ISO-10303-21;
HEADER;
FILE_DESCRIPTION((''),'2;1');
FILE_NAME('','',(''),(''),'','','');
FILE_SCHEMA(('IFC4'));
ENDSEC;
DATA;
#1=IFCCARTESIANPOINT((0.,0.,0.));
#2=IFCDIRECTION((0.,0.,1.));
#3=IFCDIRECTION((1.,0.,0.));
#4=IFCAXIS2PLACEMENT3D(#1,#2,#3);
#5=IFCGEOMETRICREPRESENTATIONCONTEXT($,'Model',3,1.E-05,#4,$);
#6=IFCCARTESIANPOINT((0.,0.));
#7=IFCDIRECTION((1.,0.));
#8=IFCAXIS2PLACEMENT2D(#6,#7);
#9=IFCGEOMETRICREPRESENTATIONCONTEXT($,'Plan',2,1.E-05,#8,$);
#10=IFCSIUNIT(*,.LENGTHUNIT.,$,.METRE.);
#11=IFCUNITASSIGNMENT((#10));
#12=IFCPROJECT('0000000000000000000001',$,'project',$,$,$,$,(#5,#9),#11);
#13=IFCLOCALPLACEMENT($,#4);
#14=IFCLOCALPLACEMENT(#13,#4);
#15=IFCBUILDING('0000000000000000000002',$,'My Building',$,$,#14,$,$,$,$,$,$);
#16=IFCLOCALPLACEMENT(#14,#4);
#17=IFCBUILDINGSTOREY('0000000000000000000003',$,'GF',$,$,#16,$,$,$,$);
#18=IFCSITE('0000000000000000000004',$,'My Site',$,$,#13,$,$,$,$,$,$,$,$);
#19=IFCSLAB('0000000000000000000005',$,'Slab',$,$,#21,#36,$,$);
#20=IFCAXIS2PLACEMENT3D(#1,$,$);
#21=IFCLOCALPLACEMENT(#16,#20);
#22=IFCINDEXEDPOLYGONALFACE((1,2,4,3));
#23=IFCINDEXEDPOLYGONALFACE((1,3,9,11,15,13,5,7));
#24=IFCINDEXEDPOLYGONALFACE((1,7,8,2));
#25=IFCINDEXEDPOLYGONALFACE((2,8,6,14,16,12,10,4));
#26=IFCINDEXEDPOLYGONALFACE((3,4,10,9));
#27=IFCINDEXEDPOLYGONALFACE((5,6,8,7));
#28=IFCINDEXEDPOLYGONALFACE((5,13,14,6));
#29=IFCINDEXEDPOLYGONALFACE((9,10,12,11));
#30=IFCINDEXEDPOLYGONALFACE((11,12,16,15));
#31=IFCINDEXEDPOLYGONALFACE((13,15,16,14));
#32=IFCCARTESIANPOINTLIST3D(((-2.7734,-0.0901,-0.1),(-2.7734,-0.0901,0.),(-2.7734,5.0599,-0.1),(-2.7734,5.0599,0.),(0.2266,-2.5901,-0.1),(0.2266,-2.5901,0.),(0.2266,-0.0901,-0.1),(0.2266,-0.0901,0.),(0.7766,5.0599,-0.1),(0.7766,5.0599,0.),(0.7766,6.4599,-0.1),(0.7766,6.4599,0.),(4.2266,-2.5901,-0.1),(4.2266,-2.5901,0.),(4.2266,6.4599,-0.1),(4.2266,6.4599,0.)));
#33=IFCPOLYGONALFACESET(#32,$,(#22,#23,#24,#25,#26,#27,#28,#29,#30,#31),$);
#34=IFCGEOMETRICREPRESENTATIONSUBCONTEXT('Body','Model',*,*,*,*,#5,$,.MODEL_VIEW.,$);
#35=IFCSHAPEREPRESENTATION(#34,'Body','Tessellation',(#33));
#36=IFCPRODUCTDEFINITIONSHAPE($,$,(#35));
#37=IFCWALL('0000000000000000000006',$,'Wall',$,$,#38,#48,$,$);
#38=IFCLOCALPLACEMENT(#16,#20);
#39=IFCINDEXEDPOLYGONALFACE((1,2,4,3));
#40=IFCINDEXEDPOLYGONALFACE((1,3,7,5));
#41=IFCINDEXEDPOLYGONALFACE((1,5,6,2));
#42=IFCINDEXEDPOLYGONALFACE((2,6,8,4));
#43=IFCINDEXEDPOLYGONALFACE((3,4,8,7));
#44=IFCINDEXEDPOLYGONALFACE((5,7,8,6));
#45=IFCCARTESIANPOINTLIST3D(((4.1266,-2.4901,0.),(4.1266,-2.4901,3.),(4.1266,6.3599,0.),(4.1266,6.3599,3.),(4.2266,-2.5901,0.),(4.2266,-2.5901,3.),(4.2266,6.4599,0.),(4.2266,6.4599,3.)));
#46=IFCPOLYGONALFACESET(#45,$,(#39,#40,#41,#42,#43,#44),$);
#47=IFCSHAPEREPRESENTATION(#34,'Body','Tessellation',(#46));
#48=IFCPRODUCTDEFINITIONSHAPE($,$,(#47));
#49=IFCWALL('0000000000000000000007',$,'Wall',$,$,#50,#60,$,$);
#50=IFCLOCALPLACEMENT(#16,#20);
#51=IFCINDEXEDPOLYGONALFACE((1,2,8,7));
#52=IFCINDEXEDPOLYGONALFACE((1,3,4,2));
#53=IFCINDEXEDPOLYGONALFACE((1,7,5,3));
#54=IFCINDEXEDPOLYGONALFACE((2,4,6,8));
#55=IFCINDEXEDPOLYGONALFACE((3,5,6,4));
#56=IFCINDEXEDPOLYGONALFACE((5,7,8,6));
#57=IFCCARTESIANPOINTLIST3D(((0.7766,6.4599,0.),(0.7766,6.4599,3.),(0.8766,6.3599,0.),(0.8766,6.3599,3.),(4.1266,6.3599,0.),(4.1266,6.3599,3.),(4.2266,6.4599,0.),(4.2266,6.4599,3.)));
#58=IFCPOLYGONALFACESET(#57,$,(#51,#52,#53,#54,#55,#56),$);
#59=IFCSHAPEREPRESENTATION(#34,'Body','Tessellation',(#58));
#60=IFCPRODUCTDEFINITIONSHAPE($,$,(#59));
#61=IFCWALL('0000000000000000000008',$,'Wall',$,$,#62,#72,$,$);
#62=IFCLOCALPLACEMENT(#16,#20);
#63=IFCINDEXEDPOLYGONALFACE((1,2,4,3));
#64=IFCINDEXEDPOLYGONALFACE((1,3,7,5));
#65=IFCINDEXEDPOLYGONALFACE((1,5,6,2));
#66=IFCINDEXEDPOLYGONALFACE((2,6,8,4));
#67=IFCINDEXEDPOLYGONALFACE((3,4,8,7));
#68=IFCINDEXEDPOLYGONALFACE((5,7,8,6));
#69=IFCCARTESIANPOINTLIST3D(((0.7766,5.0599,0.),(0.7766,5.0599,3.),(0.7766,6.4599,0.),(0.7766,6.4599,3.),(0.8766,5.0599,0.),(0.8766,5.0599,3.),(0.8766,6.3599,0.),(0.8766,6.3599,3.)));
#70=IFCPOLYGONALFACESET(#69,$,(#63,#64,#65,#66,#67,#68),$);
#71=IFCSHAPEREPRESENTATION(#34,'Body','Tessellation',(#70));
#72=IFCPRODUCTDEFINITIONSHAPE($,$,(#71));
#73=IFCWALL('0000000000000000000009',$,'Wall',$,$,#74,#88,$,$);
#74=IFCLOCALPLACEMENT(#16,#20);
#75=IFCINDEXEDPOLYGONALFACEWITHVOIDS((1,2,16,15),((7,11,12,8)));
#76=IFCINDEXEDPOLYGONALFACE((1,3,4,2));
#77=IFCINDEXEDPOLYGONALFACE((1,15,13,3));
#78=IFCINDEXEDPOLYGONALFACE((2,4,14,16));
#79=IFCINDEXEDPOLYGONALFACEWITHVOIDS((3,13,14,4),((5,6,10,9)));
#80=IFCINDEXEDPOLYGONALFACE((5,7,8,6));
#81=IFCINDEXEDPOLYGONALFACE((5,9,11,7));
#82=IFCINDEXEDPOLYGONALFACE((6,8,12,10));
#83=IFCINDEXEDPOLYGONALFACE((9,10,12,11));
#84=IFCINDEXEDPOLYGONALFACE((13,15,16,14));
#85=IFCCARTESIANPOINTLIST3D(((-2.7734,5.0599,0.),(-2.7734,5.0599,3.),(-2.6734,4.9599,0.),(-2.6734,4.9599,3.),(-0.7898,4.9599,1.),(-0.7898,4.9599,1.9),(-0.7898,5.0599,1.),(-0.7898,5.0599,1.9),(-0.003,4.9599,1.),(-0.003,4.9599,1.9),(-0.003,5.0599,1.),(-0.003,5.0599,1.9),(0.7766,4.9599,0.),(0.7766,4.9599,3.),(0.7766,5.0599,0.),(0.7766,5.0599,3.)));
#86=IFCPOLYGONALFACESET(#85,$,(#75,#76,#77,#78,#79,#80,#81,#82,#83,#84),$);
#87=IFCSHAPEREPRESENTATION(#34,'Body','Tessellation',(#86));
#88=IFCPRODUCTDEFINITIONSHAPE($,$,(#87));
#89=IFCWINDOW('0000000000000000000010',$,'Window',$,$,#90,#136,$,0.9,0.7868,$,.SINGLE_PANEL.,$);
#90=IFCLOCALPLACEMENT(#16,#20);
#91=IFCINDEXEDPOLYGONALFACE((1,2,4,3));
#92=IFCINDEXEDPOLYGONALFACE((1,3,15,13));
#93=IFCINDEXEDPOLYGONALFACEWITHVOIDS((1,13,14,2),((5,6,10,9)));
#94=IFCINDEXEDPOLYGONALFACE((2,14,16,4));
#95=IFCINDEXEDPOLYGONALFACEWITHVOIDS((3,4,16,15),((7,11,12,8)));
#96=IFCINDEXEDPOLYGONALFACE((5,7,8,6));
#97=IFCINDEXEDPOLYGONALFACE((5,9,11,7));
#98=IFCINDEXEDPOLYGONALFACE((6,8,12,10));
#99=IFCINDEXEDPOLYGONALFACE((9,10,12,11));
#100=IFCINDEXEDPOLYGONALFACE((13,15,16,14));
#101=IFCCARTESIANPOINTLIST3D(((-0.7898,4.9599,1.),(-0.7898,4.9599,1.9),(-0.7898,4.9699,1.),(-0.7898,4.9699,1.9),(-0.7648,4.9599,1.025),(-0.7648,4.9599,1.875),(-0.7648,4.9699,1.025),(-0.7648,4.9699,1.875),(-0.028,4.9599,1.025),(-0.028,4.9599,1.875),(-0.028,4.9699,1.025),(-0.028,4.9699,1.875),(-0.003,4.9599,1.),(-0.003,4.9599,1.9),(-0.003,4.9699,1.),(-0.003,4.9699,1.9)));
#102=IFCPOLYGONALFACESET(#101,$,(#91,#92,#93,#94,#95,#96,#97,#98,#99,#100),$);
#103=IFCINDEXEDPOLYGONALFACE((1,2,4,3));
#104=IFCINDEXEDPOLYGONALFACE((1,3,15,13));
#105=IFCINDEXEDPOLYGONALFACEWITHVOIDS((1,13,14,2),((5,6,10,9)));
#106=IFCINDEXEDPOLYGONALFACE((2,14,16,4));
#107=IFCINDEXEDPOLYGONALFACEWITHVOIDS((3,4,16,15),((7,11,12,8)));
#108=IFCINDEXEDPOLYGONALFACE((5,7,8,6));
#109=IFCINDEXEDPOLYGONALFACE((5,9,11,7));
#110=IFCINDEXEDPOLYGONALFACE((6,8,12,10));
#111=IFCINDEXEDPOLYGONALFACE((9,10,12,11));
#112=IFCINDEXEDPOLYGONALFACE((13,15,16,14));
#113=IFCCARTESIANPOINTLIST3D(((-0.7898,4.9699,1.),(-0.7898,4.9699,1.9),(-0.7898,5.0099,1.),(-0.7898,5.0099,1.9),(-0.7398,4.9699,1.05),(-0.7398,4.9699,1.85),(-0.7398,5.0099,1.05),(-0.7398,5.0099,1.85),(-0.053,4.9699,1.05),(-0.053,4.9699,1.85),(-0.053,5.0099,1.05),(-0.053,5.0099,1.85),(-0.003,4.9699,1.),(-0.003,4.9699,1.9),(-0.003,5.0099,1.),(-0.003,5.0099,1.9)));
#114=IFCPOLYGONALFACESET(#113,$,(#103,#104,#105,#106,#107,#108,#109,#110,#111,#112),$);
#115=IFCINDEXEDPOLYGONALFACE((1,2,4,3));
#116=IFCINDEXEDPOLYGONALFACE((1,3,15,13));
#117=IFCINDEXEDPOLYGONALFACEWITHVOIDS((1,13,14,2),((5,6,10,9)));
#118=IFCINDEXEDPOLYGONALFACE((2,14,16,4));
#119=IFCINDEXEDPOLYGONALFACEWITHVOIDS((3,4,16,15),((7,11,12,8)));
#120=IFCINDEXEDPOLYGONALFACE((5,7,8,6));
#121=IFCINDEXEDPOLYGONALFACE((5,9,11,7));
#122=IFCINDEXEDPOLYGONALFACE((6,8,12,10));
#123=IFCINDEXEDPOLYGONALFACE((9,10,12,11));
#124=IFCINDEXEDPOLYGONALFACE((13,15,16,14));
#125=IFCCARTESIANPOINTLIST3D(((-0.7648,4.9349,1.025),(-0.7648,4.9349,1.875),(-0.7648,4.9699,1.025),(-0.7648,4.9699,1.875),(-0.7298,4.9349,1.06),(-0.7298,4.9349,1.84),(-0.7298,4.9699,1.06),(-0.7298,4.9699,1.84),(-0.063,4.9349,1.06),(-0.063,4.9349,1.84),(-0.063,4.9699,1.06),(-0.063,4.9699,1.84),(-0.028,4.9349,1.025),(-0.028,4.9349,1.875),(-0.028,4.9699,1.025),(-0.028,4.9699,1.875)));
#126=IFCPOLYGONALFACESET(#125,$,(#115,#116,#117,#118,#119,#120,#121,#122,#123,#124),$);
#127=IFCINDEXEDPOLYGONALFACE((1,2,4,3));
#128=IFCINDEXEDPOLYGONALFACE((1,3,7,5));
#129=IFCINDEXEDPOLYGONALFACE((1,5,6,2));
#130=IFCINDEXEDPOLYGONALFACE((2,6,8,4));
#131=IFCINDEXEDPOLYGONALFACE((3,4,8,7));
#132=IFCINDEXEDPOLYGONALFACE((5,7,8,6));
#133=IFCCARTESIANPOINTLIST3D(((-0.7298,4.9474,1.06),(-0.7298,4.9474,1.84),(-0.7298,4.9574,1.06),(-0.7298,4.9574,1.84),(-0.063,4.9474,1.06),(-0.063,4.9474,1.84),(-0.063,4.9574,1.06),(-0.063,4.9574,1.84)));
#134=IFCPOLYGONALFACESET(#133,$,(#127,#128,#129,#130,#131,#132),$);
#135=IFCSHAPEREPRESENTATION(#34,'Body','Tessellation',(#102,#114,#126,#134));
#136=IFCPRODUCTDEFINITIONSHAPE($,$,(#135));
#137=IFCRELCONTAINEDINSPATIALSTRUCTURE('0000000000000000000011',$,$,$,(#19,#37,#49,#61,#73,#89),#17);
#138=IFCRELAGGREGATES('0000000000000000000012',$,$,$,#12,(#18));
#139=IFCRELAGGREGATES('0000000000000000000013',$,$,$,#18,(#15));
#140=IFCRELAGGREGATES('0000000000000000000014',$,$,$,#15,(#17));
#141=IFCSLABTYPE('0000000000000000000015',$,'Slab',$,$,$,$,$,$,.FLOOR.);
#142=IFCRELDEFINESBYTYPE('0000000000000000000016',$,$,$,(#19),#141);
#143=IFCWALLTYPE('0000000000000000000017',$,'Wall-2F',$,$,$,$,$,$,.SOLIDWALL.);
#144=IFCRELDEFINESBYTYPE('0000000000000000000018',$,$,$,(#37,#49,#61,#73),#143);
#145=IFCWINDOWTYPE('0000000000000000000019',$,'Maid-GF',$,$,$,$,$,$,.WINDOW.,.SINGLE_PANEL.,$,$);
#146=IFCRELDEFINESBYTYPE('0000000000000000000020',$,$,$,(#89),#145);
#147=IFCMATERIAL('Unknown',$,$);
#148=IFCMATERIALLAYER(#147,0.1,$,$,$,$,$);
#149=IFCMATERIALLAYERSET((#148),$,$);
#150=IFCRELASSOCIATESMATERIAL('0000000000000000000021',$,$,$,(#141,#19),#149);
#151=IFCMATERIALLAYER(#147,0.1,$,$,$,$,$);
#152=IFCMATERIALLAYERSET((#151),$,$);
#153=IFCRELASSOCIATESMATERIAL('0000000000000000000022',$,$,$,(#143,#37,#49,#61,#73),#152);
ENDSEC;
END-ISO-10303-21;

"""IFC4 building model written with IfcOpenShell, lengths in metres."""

from ifc_helpers import new_model, entity, si_unit, frame, origin_with_axes, origin_2d_with_axis, place, context, subcontext, project, spatial, line, indexed_curve, outline, extrude, shape, source, transform, mapped, material, layer, layer_set, layer_usage, type_object, type_shapes, element, fill, save


model = new_model("IFC4")

# Units and contexts
model_context = context("Model", 3, precision=1e-05, world=origin_with_axes())
plan_context = context("Plan", 2, precision=1e-05, world=origin_2d_with_axis())
body_context_1 = subcontext(model_context, "Body", "Model", "MODEL_VIEW")
body_context_2 = subcontext(plan_context, "Body", "Plan", "PLAN_VIEW")
ifc_project = project(units=[si_unit("LENGTHUNIT", "METRE")], contexts=[model_context, plan_context])

# Site, building, storey
site_placement = place(None, origin_with_axes())
site = spatial("IfcSite", under=ifc_project, at=site_placement, Name="My Site")
building_placement = place(site_placement, origin_with_axes())
building = spatial("IfcBuilding", under=site, at=building_placement, Name="My Building")
storey_placement = place(building_placement, origin_with_axes())
storey = spatial("IfcBuildingStorey", under=building, at=storey_placement, Name="GF")

# Slab
ifc_material = material(Name="Unknown")
ifc_layer_1 = layer(ifc_material, 0.1)
ifc_layer_set_1 = layer_set([ifc_layer_1])
ifc_layer_usage_1 = layer_usage(ifc_layer_set_1, "AXIS3", "POSITIVE", -0.1)
slab_type = type_object("IfcSlabType", Name="Slab", PredefinedType="FLOOR", material=ifc_layer_set_1)
slab_placement = place(storey_placement, frame((4.2266, -2.5901, 0.0), z_axis=(0.0, 0.0, 1.0), x_axis=(1.0, 0.0, 0.0)))
element("IfcSlab", 1, at=slab_placement, inside=storey, type_object=slab_type, material=ifc_layer_usage_1, Name="Slab", context=body_context_1, shape_type="SweptSolid", body=[
    extrude(outline(indexed_curve([(0.0, 0.0), (0.0, 9.05), (-3.45, 9.05), (-3.45, 7.65), (-7.0, 7.65), (-7.0, 2.5), (-4.0, 2.5), (-4.0, 0.0), (0.0, 0.0)])), frame((0.0, 0.0, -0.1), z_axis=(0.0, 0.0, 1.0), x_axis=(1.0, 0.0, 0.0)), (0.0, 0.0, 1.0), 0.1),
])

# Shared definitions
ifc_layer_2 = layer(ifc_material, 0.1)
ifc_layer_set_2 = layer_set([ifc_layer_2])
wall_type = type_object("IfcWallType", Name="Wall-2F", PredefinedType="SOLIDWALL", material=ifc_layer_set_2)

# Walls
ifc_layer_usage_2 = layer_usage(ifc_layer_set_2, "AXIS2", "POSITIVE", 0.0)
wall_1_placement = place(storey_placement, frame((4.2266, -2.5901, 0.0), z_axis=(0.0, 0.0, 1.0), x_axis=(0.0, 1.0, 0.0)))
element("IfcWall", 2, at=wall_1_placement, inside=storey, type_object=wall_type, material=ifc_layer_usage_2, Name="Wall", context=body_context_1, shape_type="SweptSolid", body=[
    extrude(outline(indexed_curve([(0.0, 0.0), (0.1, 0.1), (8.95, 0.1), (9.05, 0.0)], segments=[line(1, 2, 3, 4, 1)])), origin_with_axes(), (0.0, 0.0, 1.0), 3.0),
])
ifc_layer_usage_3 = layer_usage(ifc_layer_set_2, "AXIS2", "POSITIVE", 0.0)
wall_2_placement = place(storey_placement, frame((4.2266, 6.4599, 0.0), z_axis=(0.0, 0.0, 1.0), x_axis=(-1.0, 0.0, 0.0)))
element("IfcWall", 3, at=wall_2_placement, inside=storey, type_object=wall_type, material=ifc_layer_usage_3, Name="Wall", context=body_context_1, shape_type="SweptSolid", body=[
    extrude(outline(indexed_curve([(0.0, 0.0), (0.1, 0.1), (3.35, 0.1), (3.45, 0.0)], segments=[line(1, 2, 3, 4, 1)])), origin_with_axes(), (0.0, 0.0, 1.0), 3.0),
])
ifc_layer_usage_4 = layer_usage(ifc_layer_set_2, "AXIS2", "POSITIVE", 0.0)
wall_3_placement = place(storey_placement, frame((0.7766, 6.4599, 0.0), z_axis=(0.0, 0.0, 1.0), x_axis=(0.0, -1.0, 0.0)))
element("IfcWall", 4, at=wall_3_placement, inside=storey, type_object=wall_type, material=ifc_layer_usage_4, Name="Wall", context=body_context_1, shape_type="SweptSolid", body=[
    extrude(outline(indexed_curve([(0.0, 0.0), (0.1, 0.1), (1.4, 0.1), (1.4, 0.0)], segments=[line(1, 2, 3, 4, 1)])), origin_with_axes(), (0.0, 0.0, 1.0), 3.0),
])

# Wall, opening, window
ifc_layer_usage_5 = layer_usage(ifc_layer_set_2, "AXIS2", "POSITIVE", 0.0)
wall_4_placement = place(storey_placement, frame((0.7766, 5.0599, 0.0), z_axis=(0.0, 0.0, 1.0), x_axis=(-1.0, 0.0, 0.0)))
wall_4 = element("IfcWall", 5, at=wall_4_placement, inside=storey, type_object=wall_type, material=ifc_layer_usage_5, Name="Wall", context=body_context_1, shape_type="SweptSolid", body=[
    extrude(outline(indexed_curve([(0.0, 0.0), (0.0, 0.1), (3.45, 0.1), (3.55, 0.0)], segments=[line(1, 2, 3, 4, 1)])), origin_with_axes(), (0.0, 0.0, 1.0), 3.0),
])
shared_shape_1 = source(origin_with_axes(), body_context_1, "Body", "SweptSolid", [
    extrude(outline(indexed_curve([(0.0, 0.0), (0.7868, 0.0), (0.7868, 0.9), (0.0, 0.9)], segments=[line(1, 2, 3, 4, 1)])), frame((0.0, -0.6, 0.0), z_axis=(0.0, -1.0, 0.0), x_axis=(1.0, 0.0, 0.0)), (0.0, 0.0, -1.0), 1.2),
])
opening_1_placement = place(wall_4_placement, frame((0.7796, 0.0, 1.0), z_axis=(0.0, 0.0, 1.0), x_axis=(1.0, 0.0, 0.0)))
opening_1 = element("IfcOpeningElement", 6, at=opening_1_placement, cuts=wall_4, PredefinedType="OPENING", context=body_context_1, shape_type="MappedRepresentation", body=[
    mapped(shared_shape_1, transform((0.0, 0.0, 0.0), x_axis=(1.0, 0.0, 0.0), y_axis=(0.0, 1.0, 0.0), z_axis=(0.0, 0.0, 1.0), scale=1.0)),
])
window_type_1 = type_object("IfcWindowType", Name="Maid-GF", PartitioningType="SINGLE_PANEL", PredefinedType="WINDOW")
shared_shape_2 = source(origin_with_axes(), body_context_1, "Body", "SweptSolid", [
    extrude(outline(indexed_curve([(0.0, 0.0), (0.7868, 0.0), (0.7868, 0.9), (0.0, 0.9)], segments=[line(1, 2, 3, 4, 1)]), holes=[indexed_curve([(0.025, 0.025), (0.7618, 0.025), (0.7618, 0.875), (0.025, 0.875)], segments=[line(1, 2, 3, 4, 1)])]), frame((0.0, 0.09, 0.0), z_axis=(0.0, -1.0, 0.0), x_axis=(1.0, 0.0, 0.0)), (0.0, 0.0, -1.0), 0.01),
    extrude(outline(indexed_curve([(0.0, 0.0), (0.7868, 0.0), (0.7868, 0.9), (0.0, 0.9)], segments=[line(1, 2, 3, 4, 1)]), holes=[indexed_curve([(0.05, 0.05), (0.7368, 0.05), (0.7368, 0.85), (0.05, 0.85)], segments=[line(1, 2, 3, 4, 1)])]), frame((0.0, 0.05, 0.0), z_axis=(0.0, -1.0, 0.0), x_axis=(1.0, 0.0, 0.0)), (0.0, 0.0, -1.0), 0.04),
    extrude(outline(indexed_curve([(0.0, 0.0), (0.7368, 0.0), (0.7368, 0.85), (0.0, 0.85)], segments=[line(1, 2, 3, 4, 1)]), holes=[indexed_curve([(0.035, 0.035), (0.7018, 0.035), (0.7018, 0.815), (0.035, 0.815)], segments=[line(1, 2, 3, 4, 1)])]), frame((0.025, 0.09, 0.025), z_axis=(0.0, -1.0, 0.0), x_axis=(1.0, 0.0, 0.0)), (0.0, 0.0, -1.0), 0.035),
    extrude(outline(indexed_curve([(0.035, 0.035), (0.7018, 0.035), (0.7018, 0.815), (0.035, 0.815)], segments=[line(1, 2, 3, 4, 1)])), frame((0.025, 0.1025, 0.025), z_axis=(0.0, -1.0, 0.0), x_axis=(1.0, 0.0, 0.0)), (0.0, 0.0, -1.0), 0.01),
])
shared_shape_3 = source(origin_with_axes(), body_context_2, "Body", "Curve2D", [
    entity("IfcIndexedPolyCurve", entity("IfcCartesianPointList2D", [[0.05, 0.05], [0.7368, 0.05]])),
    entity("IfcIndexedPolyCurve", entity("IfcCartesianPointList2D", [[0.0, 0.1], [0.025, 0.1], [0.025, 0.09], [0.05, 0.09], [0.05, 0.05], [0.0, 0.05]]), [entity("IfcLineIndex", [1, 2, 3, 4, 5, 6, 1])]),
    entity("IfcIndexedPolyCurve", entity("IfcCartesianPointList2D", [[0.7868, 0.1], [0.7618, 0.1], [0.7618, 0.09], [0.7368, 0.09], [0.7368, 0.05], [0.7868, 0.05]]), [entity("IfcLineIndex", [1, 2, 3, 4, 5, 6, 1])]),
    entity("IfcIndexedPolyCurve", entity("IfcCartesianPointList2D", [[0.025, 0.09], [0.06, 0.09], [0.06, 0.125], [0.025, 0.125]]), [entity("IfcLineIndex", [1, 2, 3, 4, 1])]),
    entity("IfcIndexedPolyCurve", entity("IfcCartesianPointList2D", [[0.7618, 0.09], [0.7268, 0.09], [0.7268, 0.125], [0.7618, 0.125]]), [entity("IfcLineIndex", [1, 2, 3, 4, 1])]),
    entity("IfcIndexedPolyCurve", entity("IfcCartesianPointList2D", [[0.06, 0.09], [0.7268, 0.09]])),
    entity("IfcIndexedPolyCurve", entity("IfcCartesianPointList2D", [[0.06, 0.125], [0.7268, 0.125]])),
    entity("IfcIndexedPolyCurve", entity("IfcCartesianPointList2D", [[0.06, 0.1075], [0.7268, 0.1075]])),
])
type_shapes(window_type_1, [shared_shape_2, shared_shape_3])
window_1_placement = place(opening_1_placement, frame((0.0, 0.0, 0.0), z_axis=(0.0, 0.0, 1.0), x_axis=(1.0, 0.0, 0.0)))
window_1 = element("IfcWindow", 7, at=window_1_placement, inside=storey, type_object=window_type_1, Name="Window", OverallHeight=0.9, OverallWidth=0.7868, PartitioningType="SINGLE_PANEL", shapes=[
    shape(body_context_1, "Body", "MappedRepresentation", [mapped(shared_shape_2, transform((0.0, 0.0, 0.0), x_axis=(1.0, 0.0, 0.0), y_axis=(0.0, 1.0, 0.0), z_axis=(0.0, 0.0, 1.0), scale=1.0))]),
    shape(body_context_2, "Body", "MappedRepresentation", [mapped(shared_shape_3, transform((0.0, 0.0, 0.0), x_axis=(1.0, 0.0, 0.0), y_axis=(0.0, 1.0, 0.0), z_axis=(0.0, 0.0, 1.0), scale=1.0))]),
])
fill(opening_1, window_1)

save(model, "model.ifc")
